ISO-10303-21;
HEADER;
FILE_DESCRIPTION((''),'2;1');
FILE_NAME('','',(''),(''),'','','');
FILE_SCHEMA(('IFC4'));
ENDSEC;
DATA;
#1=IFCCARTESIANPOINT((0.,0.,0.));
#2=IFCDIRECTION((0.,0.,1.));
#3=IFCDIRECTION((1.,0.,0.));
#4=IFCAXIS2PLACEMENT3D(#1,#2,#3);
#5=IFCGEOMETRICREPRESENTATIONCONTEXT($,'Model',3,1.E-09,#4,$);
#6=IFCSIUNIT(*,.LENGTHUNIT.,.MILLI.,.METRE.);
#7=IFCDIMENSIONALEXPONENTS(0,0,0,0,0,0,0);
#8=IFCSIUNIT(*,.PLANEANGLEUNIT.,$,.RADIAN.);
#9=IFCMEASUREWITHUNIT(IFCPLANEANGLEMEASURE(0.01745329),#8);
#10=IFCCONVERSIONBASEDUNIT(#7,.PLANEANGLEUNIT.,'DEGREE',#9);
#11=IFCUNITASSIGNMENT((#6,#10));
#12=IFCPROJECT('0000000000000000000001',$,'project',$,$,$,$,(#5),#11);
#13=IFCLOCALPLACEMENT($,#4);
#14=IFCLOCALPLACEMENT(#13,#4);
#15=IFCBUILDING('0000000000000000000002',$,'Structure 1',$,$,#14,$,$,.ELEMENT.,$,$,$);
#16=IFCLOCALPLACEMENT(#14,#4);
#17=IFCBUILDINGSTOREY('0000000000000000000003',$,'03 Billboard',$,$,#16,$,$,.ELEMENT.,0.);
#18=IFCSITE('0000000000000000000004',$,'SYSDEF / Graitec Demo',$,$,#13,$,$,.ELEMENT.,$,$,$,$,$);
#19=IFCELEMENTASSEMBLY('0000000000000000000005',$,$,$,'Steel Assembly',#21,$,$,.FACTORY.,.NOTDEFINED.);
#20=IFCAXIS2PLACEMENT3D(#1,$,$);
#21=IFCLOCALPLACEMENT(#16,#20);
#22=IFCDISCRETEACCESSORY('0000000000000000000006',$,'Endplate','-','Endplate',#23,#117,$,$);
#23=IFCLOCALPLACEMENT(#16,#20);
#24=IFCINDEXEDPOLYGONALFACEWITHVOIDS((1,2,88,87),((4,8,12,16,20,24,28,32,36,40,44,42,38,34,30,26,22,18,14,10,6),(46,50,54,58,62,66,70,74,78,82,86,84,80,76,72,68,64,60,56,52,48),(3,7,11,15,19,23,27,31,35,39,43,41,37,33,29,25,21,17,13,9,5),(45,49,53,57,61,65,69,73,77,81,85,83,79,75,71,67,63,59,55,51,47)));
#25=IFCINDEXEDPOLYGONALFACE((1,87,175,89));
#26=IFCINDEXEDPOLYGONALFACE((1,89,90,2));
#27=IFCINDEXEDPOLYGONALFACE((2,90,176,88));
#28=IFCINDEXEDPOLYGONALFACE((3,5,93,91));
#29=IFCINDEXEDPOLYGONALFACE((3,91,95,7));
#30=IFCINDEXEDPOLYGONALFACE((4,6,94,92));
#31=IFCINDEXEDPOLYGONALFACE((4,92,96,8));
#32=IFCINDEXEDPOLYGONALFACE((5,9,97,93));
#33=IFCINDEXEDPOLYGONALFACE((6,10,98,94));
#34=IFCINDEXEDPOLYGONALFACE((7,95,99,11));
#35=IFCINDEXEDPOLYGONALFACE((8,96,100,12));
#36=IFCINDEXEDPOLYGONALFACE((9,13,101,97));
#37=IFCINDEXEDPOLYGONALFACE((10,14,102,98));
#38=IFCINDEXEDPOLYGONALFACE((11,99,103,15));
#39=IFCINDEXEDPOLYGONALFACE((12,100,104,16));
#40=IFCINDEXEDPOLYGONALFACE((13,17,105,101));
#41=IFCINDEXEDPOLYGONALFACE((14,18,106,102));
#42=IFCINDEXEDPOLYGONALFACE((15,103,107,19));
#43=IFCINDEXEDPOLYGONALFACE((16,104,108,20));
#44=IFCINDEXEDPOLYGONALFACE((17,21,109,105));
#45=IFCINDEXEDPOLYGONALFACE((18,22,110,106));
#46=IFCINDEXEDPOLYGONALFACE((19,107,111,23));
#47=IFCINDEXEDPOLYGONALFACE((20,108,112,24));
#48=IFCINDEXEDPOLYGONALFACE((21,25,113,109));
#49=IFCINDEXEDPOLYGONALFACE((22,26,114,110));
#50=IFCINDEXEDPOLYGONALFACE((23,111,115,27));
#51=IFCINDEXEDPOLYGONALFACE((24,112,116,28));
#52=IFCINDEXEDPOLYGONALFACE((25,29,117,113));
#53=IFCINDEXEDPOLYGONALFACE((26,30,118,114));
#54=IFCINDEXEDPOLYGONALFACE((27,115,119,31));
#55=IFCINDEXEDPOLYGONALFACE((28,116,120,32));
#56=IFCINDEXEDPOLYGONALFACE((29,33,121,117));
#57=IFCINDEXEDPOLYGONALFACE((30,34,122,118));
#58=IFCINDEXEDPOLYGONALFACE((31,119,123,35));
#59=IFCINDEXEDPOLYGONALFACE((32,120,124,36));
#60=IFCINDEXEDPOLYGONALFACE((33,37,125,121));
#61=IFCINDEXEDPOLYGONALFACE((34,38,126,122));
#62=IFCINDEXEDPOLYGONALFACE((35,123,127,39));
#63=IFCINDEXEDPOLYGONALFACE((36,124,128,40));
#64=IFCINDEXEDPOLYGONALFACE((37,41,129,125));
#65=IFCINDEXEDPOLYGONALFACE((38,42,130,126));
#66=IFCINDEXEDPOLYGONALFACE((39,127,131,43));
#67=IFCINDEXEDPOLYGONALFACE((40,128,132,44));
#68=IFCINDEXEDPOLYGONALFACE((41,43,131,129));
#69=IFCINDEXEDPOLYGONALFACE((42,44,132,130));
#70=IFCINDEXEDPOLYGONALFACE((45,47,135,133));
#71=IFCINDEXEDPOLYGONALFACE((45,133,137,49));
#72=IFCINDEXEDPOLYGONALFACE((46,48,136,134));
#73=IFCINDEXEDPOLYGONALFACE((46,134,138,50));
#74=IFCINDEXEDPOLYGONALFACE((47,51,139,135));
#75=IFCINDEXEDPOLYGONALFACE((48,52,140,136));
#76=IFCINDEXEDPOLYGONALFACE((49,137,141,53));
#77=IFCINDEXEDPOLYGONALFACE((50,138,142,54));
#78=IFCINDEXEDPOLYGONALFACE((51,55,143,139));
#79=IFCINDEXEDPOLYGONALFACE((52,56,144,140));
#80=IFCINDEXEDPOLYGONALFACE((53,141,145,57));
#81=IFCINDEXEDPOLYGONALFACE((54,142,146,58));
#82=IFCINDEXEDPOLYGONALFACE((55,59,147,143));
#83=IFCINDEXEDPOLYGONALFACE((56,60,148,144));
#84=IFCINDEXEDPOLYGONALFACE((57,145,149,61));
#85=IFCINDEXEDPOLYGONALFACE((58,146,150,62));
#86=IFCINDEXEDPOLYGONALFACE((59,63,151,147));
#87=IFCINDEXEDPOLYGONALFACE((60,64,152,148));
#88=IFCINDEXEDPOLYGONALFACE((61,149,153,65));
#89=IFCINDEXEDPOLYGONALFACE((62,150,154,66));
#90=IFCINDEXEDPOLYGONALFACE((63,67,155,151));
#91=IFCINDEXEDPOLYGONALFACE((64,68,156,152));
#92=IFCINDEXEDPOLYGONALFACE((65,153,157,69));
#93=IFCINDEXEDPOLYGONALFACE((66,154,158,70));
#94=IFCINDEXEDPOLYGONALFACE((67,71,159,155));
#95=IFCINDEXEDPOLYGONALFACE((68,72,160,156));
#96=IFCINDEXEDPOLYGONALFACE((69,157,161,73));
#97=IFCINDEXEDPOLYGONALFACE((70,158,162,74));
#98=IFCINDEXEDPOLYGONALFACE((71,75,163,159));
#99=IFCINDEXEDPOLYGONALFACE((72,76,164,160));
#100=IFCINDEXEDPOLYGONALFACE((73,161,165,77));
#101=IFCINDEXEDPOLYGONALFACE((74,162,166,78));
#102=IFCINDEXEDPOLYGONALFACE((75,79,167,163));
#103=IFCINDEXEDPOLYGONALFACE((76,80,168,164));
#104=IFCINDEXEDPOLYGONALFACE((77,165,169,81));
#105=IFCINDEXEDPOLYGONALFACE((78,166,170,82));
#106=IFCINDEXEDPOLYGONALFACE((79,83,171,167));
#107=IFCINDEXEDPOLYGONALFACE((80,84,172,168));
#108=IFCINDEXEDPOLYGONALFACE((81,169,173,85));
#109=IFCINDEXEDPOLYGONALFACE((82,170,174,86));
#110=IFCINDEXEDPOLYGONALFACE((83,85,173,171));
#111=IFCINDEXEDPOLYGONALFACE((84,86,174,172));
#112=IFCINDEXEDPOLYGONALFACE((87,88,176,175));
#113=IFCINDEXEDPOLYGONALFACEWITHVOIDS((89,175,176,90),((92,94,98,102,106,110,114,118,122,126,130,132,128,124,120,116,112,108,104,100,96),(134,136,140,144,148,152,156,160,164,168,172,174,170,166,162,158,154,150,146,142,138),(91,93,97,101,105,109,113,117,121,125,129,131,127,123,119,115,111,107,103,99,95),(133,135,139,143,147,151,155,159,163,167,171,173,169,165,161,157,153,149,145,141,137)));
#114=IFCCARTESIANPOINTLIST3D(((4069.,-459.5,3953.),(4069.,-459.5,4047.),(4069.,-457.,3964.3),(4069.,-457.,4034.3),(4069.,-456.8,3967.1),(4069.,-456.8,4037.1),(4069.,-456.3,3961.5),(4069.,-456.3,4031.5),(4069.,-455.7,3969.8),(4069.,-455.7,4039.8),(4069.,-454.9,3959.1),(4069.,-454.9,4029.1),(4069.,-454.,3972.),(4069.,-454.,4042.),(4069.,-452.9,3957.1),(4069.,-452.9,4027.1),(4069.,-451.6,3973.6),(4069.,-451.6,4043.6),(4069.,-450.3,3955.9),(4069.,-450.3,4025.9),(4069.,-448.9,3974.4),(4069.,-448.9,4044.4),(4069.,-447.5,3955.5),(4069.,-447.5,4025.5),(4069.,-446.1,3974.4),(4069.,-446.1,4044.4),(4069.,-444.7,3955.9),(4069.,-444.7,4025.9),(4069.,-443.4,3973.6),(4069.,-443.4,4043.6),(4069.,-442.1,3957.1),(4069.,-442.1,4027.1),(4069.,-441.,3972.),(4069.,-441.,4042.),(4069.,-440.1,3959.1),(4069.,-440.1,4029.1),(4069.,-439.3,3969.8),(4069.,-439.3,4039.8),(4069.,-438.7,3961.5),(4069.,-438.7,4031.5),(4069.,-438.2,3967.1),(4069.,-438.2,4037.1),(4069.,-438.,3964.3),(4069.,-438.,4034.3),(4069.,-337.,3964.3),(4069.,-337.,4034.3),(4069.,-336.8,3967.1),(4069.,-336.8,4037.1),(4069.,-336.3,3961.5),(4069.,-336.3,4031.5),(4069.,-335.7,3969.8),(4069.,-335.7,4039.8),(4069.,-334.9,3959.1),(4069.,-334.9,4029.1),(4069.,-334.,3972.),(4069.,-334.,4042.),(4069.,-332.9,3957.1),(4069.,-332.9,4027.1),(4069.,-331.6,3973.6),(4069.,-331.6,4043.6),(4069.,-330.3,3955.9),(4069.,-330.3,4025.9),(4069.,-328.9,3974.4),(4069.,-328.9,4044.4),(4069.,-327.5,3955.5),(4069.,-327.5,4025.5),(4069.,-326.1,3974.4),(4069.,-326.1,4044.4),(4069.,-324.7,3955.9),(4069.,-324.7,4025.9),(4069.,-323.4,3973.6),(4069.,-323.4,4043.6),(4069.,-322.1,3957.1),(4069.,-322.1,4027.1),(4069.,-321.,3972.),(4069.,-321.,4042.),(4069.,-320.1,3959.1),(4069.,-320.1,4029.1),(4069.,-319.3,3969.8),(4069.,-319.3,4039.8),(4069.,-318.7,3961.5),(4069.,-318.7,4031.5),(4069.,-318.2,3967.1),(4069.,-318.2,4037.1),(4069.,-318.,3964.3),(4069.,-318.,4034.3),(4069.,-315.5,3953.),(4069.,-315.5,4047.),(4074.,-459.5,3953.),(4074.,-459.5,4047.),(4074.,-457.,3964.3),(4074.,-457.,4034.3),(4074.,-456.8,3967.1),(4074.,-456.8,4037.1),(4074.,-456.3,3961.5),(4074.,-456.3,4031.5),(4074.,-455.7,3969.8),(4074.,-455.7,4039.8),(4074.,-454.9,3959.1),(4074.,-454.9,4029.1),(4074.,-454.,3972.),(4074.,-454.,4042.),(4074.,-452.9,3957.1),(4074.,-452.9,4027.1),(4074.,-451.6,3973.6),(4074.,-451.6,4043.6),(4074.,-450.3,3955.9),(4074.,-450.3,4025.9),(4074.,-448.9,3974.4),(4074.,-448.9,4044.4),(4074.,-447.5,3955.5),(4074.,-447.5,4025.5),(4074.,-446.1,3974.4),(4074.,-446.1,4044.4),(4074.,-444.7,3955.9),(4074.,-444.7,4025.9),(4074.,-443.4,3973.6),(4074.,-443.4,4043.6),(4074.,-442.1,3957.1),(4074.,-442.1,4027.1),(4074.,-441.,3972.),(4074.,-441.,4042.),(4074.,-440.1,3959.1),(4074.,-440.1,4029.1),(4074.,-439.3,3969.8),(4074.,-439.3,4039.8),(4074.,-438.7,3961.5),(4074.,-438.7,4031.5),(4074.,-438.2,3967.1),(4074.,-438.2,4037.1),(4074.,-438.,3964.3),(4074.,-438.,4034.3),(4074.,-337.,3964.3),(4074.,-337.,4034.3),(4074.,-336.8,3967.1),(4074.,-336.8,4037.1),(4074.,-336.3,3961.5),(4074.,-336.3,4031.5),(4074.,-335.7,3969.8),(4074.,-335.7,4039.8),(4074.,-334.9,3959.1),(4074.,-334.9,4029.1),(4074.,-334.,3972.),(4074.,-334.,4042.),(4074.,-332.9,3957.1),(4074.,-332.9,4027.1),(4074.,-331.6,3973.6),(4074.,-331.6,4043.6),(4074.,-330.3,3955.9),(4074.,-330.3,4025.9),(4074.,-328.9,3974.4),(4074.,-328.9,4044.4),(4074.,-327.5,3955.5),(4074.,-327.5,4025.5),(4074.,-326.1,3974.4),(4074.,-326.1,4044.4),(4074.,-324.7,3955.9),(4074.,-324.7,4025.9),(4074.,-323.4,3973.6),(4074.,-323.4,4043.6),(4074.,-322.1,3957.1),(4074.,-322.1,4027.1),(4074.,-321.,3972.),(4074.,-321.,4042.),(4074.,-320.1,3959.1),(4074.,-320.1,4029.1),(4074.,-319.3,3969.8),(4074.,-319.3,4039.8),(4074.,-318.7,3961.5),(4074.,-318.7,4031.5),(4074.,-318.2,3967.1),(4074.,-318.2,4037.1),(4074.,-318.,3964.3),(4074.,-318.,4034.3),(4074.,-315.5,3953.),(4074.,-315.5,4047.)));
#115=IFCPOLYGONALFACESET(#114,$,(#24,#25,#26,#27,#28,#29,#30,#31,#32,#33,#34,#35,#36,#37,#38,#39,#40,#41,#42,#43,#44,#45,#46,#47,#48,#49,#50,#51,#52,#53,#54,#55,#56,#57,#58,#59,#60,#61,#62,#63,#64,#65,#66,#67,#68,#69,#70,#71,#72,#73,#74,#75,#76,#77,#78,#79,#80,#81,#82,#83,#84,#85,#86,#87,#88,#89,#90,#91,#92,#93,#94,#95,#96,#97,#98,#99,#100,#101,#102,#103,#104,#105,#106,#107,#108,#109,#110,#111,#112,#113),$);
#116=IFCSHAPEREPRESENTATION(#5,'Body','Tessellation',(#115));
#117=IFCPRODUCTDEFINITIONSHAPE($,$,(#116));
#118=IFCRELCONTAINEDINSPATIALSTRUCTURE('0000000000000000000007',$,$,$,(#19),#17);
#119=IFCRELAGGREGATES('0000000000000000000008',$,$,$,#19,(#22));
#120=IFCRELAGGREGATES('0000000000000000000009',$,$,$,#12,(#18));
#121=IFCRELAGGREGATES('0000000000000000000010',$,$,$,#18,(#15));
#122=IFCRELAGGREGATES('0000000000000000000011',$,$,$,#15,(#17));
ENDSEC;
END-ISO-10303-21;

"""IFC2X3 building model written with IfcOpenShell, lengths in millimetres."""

from ifc_helpers import new_model, entity, si_unit, converted_unit, frame, frame_2d, origin, origin_with_axes, place, context, project, spatial, polyline, circle, outline, extrude, element, aggregate, save


model = new_model("IFC2X3")

# Units and contexts
model_context = context("Model", 3, precision=1e-09, world=origin_with_axes())
ifc_project = project(units=[si_unit("LENGTHUNIT", "METRE", prefix="MILLI"), converted_unit("PLANEANGLEUNIT", "DEGREE", entity("IfcPlaneAngleMeasure", 0.01745329), si_unit("PLANEANGLEUNIT", "RADIAN"), dimensions=[0, 0, 0, 0, 0, 0, 0])], contexts=[model_context])

# Site, building, storey
site_placement = place(None, origin_with_axes())
site = spatial("IfcSite", under=ifc_project, at=site_placement, Name="SYSDEF / Graitec Demo", CompositionType="ELEMENT")
building_placement = place(site_placement, origin_with_axes())
building = spatial("IfcBuilding", under=site, at=building_placement, Name="Structure 1", CompositionType="ELEMENT")
storey_placement = place(building_placement, origin_with_axes())
storey = spatial("IfcBuildingStorey", under=building, at=storey_placement, Name="03 Billboard", CompositionType="ELEMENT", Elevation=0.0)

# Element assembly, discrete accessory, openings
assembly_1_placement = place(None, frame((-4239.1, -387.5, 4000.0), z_axis=(-1.0, 0.0, 0.0), x_axis=(0.0, 0.0, 1.0)))
assembly_1 = element("IfcElementAssembly", 1, at=assembly_1_placement, inside=storey, ObjectType="Steel Assembly", AssemblyPlace="FACTORY", PredefinedType="NOTDEFINED")
discrete_accessory_1_placement = place(assembly_1_placement, frame((-47.0, 72.0, -8308.1), z_axis=(0.0, 0.0, -1.0), x_axis=(1.0, 0.0, 0.0)))
discrete_accessory_1 = element("IfcDiscreteAccessory", 2, at=discrete_accessory_1_placement, Name="Endplate", Description="-", ObjectType="Endplate", context=model_context, shape_type="SweptSolid", body=[
    extrude(outline(polyline([(0.0, 0.0), (94.0, 0.0), (94.0, 144.0), (0.0, 144.0), (0.0, 0.0)])), origin_with_axes(), (0.0, 0.0, 1.0), 5.0),
])
opening_1_placement = place(discrete_accessory_1_placement, frame((47.0, 72.0, -0.5), z_axis=(0.0, 0.0, 1.0), x_axis=(-1.0, 0.0, 0.0)))
element("IfcOpeningElement", 3, at=opening_1_placement, cuts=discrete_accessory_1, ObjectType="Opening", context=model_context, shape_type="SweptSolid", body=[
    extrude(circle(Radius=9.5, at=frame_2d((35.0, 60.0), x_axis=(1.0, 0.0))), origin(), (0.0, 0.0, 1.0), 6.0),
])
opening_2_placement = place(discrete_accessory_1_placement, frame((47.0, 72.0, -0.5), z_axis=(0.0, 0.0, 1.0), x_axis=(-1.0, 0.0, 0.0)))
element("IfcOpeningElement", 4, at=opening_2_placement, cuts=discrete_accessory_1, ObjectType="Opening", context=model_context, shape_type="SweptSolid", body=[
    extrude(circle(Radius=9.5, at=frame_2d((-35.0, 60.0), x_axis=(1.0, 0.0))), origin(), (0.0, 0.0, 1.0), 6.0),
])
opening_3_placement = place(discrete_accessory_1_placement, frame((47.0, 72.0, -0.5), z_axis=(0.0, 0.0, 1.0), x_axis=(-1.0, 0.0, 0.0)))
element("IfcOpeningElement", 5, at=opening_3_placement, cuts=discrete_accessory_1, ObjectType="Opening", context=model_context, shape_type="SweptSolid", body=[
    extrude(circle(Radius=9.5, at=frame_2d((35.0, -60.0), x_axis=(1.0, 0.0))), origin(), (0.0, 0.0, 1.0), 6.0),
])
opening_4_placement = place(discrete_accessory_1_placement, frame((47.0, 72.0, -0.5), z_axis=(0.0, 0.0, 1.0), x_axis=(-1.0, 0.0, 0.0)))
element("IfcOpeningElement", 6, at=opening_4_placement, cuts=discrete_accessory_1, ObjectType="Opening", context=model_context, shape_type="SweptSolid", body=[
    extrude(circle(Radius=9.5, at=frame_2d((-35.0, -60.0), x_axis=(1.0, 0.0))), origin(), (0.0, 0.0, 1.0), 6.0),
])
aggregate(assembly_1, [discrete_accessory_1])

save(model, "model.ifc")
